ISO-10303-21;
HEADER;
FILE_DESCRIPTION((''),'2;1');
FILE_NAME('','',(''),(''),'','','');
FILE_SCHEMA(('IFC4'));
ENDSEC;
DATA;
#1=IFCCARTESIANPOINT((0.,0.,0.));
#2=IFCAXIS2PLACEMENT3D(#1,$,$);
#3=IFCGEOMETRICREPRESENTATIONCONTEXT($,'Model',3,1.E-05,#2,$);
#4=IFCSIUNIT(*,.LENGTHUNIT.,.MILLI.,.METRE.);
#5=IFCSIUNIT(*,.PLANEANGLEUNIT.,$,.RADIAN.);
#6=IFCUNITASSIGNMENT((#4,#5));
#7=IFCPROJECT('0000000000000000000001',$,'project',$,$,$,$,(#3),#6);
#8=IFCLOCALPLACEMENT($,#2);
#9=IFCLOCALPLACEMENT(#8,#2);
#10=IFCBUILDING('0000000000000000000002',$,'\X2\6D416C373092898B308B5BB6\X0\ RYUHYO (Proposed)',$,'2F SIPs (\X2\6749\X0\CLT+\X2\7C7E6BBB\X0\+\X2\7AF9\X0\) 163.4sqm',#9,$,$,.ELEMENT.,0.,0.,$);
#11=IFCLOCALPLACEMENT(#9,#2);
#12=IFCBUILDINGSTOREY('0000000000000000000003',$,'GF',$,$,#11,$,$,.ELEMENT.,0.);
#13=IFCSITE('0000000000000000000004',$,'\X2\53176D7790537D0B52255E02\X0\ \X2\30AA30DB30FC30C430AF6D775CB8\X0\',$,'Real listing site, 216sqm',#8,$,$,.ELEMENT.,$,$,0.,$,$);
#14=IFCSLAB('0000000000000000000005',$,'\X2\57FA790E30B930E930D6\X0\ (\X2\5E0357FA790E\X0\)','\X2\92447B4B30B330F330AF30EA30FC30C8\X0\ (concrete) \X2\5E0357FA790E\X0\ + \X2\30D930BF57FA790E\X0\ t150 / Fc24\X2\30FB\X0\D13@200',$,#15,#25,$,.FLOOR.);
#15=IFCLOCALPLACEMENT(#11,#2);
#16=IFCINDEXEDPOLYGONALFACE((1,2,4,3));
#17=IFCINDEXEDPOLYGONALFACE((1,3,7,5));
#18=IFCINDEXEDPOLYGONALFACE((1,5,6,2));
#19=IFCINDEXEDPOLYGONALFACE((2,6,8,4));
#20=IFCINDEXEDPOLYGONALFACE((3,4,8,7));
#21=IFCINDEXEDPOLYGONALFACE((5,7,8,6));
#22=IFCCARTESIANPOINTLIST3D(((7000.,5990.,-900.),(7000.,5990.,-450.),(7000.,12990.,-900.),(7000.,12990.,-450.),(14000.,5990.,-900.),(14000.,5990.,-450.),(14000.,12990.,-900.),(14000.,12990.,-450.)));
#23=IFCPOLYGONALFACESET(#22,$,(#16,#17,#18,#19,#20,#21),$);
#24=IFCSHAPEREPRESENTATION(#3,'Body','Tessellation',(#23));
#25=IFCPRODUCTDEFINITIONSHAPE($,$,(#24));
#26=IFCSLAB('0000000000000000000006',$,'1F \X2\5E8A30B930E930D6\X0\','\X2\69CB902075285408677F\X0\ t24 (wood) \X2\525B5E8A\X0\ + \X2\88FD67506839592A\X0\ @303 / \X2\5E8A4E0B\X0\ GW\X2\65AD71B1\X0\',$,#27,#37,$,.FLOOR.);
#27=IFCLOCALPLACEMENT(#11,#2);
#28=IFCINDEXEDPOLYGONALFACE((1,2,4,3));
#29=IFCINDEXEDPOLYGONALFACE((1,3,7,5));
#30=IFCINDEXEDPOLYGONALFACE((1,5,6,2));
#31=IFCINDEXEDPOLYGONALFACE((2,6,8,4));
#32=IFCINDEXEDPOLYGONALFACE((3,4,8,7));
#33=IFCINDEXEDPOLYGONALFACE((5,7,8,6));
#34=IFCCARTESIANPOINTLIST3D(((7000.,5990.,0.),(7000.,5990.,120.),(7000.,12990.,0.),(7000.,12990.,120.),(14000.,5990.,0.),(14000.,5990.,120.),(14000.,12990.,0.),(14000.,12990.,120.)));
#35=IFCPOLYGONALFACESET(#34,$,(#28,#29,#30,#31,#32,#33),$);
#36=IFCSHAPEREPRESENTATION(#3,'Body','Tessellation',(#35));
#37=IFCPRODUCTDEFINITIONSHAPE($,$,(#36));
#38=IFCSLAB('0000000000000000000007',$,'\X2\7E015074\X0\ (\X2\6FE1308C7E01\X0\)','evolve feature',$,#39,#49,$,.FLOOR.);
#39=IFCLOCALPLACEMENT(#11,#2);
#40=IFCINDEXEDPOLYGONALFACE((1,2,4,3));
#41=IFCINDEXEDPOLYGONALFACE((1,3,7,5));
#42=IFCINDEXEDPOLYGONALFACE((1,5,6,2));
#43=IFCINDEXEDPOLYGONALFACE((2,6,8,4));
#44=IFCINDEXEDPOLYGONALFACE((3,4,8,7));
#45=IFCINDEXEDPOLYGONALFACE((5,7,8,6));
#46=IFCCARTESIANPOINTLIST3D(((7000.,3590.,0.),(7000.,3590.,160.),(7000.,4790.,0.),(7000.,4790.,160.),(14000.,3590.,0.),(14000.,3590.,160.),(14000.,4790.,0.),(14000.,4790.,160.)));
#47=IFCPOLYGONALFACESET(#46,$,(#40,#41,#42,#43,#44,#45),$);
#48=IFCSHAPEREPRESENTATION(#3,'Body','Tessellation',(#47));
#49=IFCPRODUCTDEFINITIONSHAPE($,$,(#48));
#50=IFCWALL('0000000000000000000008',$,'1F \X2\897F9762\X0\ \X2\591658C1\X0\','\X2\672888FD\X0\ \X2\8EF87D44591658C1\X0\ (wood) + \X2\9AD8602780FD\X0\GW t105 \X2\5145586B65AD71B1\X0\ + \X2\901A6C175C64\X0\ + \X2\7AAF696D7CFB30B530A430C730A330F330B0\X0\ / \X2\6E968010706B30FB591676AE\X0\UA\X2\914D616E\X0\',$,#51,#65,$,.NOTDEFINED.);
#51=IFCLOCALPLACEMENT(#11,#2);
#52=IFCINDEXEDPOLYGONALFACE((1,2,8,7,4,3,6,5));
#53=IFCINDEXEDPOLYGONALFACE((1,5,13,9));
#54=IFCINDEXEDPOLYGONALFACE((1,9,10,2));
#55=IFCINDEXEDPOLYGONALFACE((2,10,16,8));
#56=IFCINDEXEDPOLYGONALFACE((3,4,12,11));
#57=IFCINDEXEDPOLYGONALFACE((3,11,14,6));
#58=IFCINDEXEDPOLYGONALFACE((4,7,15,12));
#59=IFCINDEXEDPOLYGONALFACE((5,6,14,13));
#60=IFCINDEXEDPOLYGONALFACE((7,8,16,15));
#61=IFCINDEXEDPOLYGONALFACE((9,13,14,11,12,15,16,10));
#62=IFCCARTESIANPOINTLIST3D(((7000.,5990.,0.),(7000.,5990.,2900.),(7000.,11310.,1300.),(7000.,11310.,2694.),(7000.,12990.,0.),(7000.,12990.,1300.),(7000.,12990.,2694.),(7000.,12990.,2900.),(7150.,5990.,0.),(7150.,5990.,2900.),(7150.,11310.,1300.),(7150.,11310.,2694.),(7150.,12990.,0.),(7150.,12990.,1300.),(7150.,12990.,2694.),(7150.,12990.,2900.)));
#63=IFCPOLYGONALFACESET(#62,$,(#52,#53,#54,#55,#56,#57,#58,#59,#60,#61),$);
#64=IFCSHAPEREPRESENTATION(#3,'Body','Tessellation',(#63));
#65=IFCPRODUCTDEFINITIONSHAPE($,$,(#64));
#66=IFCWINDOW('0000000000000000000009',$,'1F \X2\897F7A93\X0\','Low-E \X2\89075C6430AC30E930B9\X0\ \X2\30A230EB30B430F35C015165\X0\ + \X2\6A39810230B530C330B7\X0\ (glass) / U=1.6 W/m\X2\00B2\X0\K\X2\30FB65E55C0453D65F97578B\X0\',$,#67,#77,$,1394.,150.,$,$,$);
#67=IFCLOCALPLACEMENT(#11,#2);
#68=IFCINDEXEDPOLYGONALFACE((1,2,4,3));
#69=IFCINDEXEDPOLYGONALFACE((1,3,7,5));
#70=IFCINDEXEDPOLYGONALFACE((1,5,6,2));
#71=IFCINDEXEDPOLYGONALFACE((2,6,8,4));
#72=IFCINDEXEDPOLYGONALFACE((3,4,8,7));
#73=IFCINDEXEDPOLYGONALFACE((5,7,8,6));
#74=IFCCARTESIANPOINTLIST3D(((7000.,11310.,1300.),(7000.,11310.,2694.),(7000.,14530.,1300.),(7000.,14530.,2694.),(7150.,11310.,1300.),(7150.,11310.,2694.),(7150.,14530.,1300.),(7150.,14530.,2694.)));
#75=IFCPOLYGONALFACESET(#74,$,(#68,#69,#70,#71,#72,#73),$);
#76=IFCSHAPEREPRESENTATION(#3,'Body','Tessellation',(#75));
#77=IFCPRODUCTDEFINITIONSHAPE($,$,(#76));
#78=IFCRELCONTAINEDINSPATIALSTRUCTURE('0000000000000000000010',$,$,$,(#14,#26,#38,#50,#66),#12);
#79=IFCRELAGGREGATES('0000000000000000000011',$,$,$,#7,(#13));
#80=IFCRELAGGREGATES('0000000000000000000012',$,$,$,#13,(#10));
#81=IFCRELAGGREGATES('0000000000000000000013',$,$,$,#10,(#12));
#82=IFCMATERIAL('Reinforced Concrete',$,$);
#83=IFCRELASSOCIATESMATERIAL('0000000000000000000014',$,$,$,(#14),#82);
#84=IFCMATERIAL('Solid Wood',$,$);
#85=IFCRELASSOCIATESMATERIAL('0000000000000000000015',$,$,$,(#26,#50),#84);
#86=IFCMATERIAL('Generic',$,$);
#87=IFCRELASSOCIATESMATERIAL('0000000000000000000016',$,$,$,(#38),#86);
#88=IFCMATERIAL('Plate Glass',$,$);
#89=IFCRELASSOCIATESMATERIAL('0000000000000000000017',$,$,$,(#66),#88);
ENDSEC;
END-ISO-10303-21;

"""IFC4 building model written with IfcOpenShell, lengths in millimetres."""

from ifc_helpers import new_model, si_unit, frame, frame_2d, origin, place, context, project, spatial, rectangle, extrude, material, element, fill, save


model = new_model("IFC4")

# Units and contexts
model_context = context("Model", 3, precision=1e-05, world=origin())
ifc_project = project(units=[si_unit("LENGTHUNIT", "METRE", prefix="MILLI"), si_unit("PLANEANGLEUNIT", "RADIAN")], contexts=[model_context])

# Site, building, storey
site_placement = place(None, origin())
site = spatial("IfcSite", under=ifc_project, at=site_placement, Name="北海道紋別市 オホーツク海岸", ObjectType="Real listing site, 216sqm", CompositionType="ELEMENT", RefElevation=0.0)
building_placement = place(site_placement, origin())
building = spatial("IfcBuilding", under=site, at=building_placement, Name="流氷を見る家 RYUHYO (Proposed)", ObjectType="2F SIPs (杉CLT+籾殻+竹) 163.4sqm", CompositionType="ELEMENT", ElevationOfRefHeight=0.0, ElevationOfTerrain=0.0)
storey_placement = place(building_placement, origin())
storey = spatial("IfcBuildingStorey", under=building, at=storey_placement, Name="GF", CompositionType="ELEMENT", Elevation=0.0)

# Slabs
ifc_material_1 = material(Name="Reinforced Concrete")
slab_1_placement = place(storey_placement, frame((3500.0, 2995.0, -450.0)))
element("IfcSlab", 1, at=slab_1_placement, inside=storey, material=ifc_material_1, Name="基礎スラブ (布基礎)", Description="鉄筋コンクリート (concrete) 布基礎 + ベタ基礎 t150 / Fc24・D13@200", PredefinedType="FLOOR", context=model_context, shape_type="SweptSolid", body=[
    extrude(rectangle(XDim=7000.0, YDim=7000.0, at=frame_2d((3500.0, 3500.0))), frame((3500.0, 2995.0, -450.0)), (0.0, 0.0, 1.0), 450.0),
])
ifc_material_2 = material(Name="Solid Wood")
slab_2_placement = place(storey_placement, frame((3500.0, 2995.0, 0.0)))
element("IfcSlab", 2, at=slab_2_placement, inside=storey, material=ifc_material_2, Name="1F 床スラブ", Description="構造用合板 t24 (wood) 剛床 + 製材根太 @303 / 床下 GW断熱", PredefinedType="FLOOR", context=model_context, shape_type="SweptSolid", body=[
    extrude(rectangle(XDim=7000.0, YDim=7000.0, at=frame_2d((3500.0, 3500.0))), frame((3500.0, 2995.0, 0.0)), (0.0, 0.0, 1.0), 120.0),
])
ifc_material_3 = material(Name="Generic")
slab_3_placement = place(storey_placement, frame((3500.0, 1795.0, 0.0)))
element("IfcSlab", 3, at=slab_3_placement, inside=storey, material=ifc_material_3, Name="縁側 (濡れ縁)", Description="evolve feature", PredefinedType="FLOOR", context=model_context, shape_type="SweptSolid", body=[
    extrude(rectangle(XDim=7000.0, YDim=1200.0, at=frame_2d((3500.0, 600.0))), frame((3500.0, 1795.0, 0.0)), (0.0, 0.0, 1.0), 160.0),
])

# Shared definitions
ifc_material_4 = material(Name="Plate Glass")

# Wall, opening, window
wall_1_placement = place(storey_placement, frame((3500.0, 2995.0, 0.0)))
wall_1 = element("IfcWall", 4, at=wall_1_placement, inside=storey, material=ifc_material_2, Name="1F 西面 外壁", Description="木製 軸組外壁 (wood) + 高性能GW t105 充填断熱 + 通気層 + 窯業系サイディング / 準耐火・外皮UA配慮", PredefinedType="NOTDEFINED", context=model_context, shape_type="SweptSolid", body=[
    extrude(rectangle(XDim=150.0, YDim=7000.0, at=frame_2d((75.0, 3500.0))), frame((3500.0, 2995.0, 0.0)), (0.0, 0.0, 1.0), 2900.0),
])
opening_1_placement = place(storey_placement, frame((3500.0, 5655.0, 650.0)))
opening_1 = element("IfcOpeningElement", 5, at=opening_1_placement, cuts=wall_1, PredefinedType="NOTDEFINED", context=model_context, shape_type="SweptSolid", body=[
    extrude(rectangle(XDim=150.0, YDim=3220.0, at=frame_2d((75.0, 1610.0))), frame((3500.0, 5655.0, 650.0)), (0.0, 0.0, 1.0), 1394.0),
])
window_1_placement = place(storey_placement, frame((3500.0, 5655.0, 650.0)))
window_1 = element("IfcWindow", 6, at=window_1_placement, inside=storey, material=ifc_material_4, Name="1F 西窓", Description="Low-E 複層ガラス アルゴン封入 + 樹脂サッシ (glass) / U=1.6 W/m²K・日射取得型", OverallHeight=1394.0, OverallWidth=150.0, context=model_context, shape_type="SweptSolid", body=[
    extrude(rectangle(XDim=150.0, YDim=3220.0, at=frame_2d((75.0, 1610.0))), frame((3500.0, 5655.0, 650.0)), (0.0, 0.0, 1.0), 1394.0),
])
fill(opening_1, window_1)

save(model, "model.ifc")
